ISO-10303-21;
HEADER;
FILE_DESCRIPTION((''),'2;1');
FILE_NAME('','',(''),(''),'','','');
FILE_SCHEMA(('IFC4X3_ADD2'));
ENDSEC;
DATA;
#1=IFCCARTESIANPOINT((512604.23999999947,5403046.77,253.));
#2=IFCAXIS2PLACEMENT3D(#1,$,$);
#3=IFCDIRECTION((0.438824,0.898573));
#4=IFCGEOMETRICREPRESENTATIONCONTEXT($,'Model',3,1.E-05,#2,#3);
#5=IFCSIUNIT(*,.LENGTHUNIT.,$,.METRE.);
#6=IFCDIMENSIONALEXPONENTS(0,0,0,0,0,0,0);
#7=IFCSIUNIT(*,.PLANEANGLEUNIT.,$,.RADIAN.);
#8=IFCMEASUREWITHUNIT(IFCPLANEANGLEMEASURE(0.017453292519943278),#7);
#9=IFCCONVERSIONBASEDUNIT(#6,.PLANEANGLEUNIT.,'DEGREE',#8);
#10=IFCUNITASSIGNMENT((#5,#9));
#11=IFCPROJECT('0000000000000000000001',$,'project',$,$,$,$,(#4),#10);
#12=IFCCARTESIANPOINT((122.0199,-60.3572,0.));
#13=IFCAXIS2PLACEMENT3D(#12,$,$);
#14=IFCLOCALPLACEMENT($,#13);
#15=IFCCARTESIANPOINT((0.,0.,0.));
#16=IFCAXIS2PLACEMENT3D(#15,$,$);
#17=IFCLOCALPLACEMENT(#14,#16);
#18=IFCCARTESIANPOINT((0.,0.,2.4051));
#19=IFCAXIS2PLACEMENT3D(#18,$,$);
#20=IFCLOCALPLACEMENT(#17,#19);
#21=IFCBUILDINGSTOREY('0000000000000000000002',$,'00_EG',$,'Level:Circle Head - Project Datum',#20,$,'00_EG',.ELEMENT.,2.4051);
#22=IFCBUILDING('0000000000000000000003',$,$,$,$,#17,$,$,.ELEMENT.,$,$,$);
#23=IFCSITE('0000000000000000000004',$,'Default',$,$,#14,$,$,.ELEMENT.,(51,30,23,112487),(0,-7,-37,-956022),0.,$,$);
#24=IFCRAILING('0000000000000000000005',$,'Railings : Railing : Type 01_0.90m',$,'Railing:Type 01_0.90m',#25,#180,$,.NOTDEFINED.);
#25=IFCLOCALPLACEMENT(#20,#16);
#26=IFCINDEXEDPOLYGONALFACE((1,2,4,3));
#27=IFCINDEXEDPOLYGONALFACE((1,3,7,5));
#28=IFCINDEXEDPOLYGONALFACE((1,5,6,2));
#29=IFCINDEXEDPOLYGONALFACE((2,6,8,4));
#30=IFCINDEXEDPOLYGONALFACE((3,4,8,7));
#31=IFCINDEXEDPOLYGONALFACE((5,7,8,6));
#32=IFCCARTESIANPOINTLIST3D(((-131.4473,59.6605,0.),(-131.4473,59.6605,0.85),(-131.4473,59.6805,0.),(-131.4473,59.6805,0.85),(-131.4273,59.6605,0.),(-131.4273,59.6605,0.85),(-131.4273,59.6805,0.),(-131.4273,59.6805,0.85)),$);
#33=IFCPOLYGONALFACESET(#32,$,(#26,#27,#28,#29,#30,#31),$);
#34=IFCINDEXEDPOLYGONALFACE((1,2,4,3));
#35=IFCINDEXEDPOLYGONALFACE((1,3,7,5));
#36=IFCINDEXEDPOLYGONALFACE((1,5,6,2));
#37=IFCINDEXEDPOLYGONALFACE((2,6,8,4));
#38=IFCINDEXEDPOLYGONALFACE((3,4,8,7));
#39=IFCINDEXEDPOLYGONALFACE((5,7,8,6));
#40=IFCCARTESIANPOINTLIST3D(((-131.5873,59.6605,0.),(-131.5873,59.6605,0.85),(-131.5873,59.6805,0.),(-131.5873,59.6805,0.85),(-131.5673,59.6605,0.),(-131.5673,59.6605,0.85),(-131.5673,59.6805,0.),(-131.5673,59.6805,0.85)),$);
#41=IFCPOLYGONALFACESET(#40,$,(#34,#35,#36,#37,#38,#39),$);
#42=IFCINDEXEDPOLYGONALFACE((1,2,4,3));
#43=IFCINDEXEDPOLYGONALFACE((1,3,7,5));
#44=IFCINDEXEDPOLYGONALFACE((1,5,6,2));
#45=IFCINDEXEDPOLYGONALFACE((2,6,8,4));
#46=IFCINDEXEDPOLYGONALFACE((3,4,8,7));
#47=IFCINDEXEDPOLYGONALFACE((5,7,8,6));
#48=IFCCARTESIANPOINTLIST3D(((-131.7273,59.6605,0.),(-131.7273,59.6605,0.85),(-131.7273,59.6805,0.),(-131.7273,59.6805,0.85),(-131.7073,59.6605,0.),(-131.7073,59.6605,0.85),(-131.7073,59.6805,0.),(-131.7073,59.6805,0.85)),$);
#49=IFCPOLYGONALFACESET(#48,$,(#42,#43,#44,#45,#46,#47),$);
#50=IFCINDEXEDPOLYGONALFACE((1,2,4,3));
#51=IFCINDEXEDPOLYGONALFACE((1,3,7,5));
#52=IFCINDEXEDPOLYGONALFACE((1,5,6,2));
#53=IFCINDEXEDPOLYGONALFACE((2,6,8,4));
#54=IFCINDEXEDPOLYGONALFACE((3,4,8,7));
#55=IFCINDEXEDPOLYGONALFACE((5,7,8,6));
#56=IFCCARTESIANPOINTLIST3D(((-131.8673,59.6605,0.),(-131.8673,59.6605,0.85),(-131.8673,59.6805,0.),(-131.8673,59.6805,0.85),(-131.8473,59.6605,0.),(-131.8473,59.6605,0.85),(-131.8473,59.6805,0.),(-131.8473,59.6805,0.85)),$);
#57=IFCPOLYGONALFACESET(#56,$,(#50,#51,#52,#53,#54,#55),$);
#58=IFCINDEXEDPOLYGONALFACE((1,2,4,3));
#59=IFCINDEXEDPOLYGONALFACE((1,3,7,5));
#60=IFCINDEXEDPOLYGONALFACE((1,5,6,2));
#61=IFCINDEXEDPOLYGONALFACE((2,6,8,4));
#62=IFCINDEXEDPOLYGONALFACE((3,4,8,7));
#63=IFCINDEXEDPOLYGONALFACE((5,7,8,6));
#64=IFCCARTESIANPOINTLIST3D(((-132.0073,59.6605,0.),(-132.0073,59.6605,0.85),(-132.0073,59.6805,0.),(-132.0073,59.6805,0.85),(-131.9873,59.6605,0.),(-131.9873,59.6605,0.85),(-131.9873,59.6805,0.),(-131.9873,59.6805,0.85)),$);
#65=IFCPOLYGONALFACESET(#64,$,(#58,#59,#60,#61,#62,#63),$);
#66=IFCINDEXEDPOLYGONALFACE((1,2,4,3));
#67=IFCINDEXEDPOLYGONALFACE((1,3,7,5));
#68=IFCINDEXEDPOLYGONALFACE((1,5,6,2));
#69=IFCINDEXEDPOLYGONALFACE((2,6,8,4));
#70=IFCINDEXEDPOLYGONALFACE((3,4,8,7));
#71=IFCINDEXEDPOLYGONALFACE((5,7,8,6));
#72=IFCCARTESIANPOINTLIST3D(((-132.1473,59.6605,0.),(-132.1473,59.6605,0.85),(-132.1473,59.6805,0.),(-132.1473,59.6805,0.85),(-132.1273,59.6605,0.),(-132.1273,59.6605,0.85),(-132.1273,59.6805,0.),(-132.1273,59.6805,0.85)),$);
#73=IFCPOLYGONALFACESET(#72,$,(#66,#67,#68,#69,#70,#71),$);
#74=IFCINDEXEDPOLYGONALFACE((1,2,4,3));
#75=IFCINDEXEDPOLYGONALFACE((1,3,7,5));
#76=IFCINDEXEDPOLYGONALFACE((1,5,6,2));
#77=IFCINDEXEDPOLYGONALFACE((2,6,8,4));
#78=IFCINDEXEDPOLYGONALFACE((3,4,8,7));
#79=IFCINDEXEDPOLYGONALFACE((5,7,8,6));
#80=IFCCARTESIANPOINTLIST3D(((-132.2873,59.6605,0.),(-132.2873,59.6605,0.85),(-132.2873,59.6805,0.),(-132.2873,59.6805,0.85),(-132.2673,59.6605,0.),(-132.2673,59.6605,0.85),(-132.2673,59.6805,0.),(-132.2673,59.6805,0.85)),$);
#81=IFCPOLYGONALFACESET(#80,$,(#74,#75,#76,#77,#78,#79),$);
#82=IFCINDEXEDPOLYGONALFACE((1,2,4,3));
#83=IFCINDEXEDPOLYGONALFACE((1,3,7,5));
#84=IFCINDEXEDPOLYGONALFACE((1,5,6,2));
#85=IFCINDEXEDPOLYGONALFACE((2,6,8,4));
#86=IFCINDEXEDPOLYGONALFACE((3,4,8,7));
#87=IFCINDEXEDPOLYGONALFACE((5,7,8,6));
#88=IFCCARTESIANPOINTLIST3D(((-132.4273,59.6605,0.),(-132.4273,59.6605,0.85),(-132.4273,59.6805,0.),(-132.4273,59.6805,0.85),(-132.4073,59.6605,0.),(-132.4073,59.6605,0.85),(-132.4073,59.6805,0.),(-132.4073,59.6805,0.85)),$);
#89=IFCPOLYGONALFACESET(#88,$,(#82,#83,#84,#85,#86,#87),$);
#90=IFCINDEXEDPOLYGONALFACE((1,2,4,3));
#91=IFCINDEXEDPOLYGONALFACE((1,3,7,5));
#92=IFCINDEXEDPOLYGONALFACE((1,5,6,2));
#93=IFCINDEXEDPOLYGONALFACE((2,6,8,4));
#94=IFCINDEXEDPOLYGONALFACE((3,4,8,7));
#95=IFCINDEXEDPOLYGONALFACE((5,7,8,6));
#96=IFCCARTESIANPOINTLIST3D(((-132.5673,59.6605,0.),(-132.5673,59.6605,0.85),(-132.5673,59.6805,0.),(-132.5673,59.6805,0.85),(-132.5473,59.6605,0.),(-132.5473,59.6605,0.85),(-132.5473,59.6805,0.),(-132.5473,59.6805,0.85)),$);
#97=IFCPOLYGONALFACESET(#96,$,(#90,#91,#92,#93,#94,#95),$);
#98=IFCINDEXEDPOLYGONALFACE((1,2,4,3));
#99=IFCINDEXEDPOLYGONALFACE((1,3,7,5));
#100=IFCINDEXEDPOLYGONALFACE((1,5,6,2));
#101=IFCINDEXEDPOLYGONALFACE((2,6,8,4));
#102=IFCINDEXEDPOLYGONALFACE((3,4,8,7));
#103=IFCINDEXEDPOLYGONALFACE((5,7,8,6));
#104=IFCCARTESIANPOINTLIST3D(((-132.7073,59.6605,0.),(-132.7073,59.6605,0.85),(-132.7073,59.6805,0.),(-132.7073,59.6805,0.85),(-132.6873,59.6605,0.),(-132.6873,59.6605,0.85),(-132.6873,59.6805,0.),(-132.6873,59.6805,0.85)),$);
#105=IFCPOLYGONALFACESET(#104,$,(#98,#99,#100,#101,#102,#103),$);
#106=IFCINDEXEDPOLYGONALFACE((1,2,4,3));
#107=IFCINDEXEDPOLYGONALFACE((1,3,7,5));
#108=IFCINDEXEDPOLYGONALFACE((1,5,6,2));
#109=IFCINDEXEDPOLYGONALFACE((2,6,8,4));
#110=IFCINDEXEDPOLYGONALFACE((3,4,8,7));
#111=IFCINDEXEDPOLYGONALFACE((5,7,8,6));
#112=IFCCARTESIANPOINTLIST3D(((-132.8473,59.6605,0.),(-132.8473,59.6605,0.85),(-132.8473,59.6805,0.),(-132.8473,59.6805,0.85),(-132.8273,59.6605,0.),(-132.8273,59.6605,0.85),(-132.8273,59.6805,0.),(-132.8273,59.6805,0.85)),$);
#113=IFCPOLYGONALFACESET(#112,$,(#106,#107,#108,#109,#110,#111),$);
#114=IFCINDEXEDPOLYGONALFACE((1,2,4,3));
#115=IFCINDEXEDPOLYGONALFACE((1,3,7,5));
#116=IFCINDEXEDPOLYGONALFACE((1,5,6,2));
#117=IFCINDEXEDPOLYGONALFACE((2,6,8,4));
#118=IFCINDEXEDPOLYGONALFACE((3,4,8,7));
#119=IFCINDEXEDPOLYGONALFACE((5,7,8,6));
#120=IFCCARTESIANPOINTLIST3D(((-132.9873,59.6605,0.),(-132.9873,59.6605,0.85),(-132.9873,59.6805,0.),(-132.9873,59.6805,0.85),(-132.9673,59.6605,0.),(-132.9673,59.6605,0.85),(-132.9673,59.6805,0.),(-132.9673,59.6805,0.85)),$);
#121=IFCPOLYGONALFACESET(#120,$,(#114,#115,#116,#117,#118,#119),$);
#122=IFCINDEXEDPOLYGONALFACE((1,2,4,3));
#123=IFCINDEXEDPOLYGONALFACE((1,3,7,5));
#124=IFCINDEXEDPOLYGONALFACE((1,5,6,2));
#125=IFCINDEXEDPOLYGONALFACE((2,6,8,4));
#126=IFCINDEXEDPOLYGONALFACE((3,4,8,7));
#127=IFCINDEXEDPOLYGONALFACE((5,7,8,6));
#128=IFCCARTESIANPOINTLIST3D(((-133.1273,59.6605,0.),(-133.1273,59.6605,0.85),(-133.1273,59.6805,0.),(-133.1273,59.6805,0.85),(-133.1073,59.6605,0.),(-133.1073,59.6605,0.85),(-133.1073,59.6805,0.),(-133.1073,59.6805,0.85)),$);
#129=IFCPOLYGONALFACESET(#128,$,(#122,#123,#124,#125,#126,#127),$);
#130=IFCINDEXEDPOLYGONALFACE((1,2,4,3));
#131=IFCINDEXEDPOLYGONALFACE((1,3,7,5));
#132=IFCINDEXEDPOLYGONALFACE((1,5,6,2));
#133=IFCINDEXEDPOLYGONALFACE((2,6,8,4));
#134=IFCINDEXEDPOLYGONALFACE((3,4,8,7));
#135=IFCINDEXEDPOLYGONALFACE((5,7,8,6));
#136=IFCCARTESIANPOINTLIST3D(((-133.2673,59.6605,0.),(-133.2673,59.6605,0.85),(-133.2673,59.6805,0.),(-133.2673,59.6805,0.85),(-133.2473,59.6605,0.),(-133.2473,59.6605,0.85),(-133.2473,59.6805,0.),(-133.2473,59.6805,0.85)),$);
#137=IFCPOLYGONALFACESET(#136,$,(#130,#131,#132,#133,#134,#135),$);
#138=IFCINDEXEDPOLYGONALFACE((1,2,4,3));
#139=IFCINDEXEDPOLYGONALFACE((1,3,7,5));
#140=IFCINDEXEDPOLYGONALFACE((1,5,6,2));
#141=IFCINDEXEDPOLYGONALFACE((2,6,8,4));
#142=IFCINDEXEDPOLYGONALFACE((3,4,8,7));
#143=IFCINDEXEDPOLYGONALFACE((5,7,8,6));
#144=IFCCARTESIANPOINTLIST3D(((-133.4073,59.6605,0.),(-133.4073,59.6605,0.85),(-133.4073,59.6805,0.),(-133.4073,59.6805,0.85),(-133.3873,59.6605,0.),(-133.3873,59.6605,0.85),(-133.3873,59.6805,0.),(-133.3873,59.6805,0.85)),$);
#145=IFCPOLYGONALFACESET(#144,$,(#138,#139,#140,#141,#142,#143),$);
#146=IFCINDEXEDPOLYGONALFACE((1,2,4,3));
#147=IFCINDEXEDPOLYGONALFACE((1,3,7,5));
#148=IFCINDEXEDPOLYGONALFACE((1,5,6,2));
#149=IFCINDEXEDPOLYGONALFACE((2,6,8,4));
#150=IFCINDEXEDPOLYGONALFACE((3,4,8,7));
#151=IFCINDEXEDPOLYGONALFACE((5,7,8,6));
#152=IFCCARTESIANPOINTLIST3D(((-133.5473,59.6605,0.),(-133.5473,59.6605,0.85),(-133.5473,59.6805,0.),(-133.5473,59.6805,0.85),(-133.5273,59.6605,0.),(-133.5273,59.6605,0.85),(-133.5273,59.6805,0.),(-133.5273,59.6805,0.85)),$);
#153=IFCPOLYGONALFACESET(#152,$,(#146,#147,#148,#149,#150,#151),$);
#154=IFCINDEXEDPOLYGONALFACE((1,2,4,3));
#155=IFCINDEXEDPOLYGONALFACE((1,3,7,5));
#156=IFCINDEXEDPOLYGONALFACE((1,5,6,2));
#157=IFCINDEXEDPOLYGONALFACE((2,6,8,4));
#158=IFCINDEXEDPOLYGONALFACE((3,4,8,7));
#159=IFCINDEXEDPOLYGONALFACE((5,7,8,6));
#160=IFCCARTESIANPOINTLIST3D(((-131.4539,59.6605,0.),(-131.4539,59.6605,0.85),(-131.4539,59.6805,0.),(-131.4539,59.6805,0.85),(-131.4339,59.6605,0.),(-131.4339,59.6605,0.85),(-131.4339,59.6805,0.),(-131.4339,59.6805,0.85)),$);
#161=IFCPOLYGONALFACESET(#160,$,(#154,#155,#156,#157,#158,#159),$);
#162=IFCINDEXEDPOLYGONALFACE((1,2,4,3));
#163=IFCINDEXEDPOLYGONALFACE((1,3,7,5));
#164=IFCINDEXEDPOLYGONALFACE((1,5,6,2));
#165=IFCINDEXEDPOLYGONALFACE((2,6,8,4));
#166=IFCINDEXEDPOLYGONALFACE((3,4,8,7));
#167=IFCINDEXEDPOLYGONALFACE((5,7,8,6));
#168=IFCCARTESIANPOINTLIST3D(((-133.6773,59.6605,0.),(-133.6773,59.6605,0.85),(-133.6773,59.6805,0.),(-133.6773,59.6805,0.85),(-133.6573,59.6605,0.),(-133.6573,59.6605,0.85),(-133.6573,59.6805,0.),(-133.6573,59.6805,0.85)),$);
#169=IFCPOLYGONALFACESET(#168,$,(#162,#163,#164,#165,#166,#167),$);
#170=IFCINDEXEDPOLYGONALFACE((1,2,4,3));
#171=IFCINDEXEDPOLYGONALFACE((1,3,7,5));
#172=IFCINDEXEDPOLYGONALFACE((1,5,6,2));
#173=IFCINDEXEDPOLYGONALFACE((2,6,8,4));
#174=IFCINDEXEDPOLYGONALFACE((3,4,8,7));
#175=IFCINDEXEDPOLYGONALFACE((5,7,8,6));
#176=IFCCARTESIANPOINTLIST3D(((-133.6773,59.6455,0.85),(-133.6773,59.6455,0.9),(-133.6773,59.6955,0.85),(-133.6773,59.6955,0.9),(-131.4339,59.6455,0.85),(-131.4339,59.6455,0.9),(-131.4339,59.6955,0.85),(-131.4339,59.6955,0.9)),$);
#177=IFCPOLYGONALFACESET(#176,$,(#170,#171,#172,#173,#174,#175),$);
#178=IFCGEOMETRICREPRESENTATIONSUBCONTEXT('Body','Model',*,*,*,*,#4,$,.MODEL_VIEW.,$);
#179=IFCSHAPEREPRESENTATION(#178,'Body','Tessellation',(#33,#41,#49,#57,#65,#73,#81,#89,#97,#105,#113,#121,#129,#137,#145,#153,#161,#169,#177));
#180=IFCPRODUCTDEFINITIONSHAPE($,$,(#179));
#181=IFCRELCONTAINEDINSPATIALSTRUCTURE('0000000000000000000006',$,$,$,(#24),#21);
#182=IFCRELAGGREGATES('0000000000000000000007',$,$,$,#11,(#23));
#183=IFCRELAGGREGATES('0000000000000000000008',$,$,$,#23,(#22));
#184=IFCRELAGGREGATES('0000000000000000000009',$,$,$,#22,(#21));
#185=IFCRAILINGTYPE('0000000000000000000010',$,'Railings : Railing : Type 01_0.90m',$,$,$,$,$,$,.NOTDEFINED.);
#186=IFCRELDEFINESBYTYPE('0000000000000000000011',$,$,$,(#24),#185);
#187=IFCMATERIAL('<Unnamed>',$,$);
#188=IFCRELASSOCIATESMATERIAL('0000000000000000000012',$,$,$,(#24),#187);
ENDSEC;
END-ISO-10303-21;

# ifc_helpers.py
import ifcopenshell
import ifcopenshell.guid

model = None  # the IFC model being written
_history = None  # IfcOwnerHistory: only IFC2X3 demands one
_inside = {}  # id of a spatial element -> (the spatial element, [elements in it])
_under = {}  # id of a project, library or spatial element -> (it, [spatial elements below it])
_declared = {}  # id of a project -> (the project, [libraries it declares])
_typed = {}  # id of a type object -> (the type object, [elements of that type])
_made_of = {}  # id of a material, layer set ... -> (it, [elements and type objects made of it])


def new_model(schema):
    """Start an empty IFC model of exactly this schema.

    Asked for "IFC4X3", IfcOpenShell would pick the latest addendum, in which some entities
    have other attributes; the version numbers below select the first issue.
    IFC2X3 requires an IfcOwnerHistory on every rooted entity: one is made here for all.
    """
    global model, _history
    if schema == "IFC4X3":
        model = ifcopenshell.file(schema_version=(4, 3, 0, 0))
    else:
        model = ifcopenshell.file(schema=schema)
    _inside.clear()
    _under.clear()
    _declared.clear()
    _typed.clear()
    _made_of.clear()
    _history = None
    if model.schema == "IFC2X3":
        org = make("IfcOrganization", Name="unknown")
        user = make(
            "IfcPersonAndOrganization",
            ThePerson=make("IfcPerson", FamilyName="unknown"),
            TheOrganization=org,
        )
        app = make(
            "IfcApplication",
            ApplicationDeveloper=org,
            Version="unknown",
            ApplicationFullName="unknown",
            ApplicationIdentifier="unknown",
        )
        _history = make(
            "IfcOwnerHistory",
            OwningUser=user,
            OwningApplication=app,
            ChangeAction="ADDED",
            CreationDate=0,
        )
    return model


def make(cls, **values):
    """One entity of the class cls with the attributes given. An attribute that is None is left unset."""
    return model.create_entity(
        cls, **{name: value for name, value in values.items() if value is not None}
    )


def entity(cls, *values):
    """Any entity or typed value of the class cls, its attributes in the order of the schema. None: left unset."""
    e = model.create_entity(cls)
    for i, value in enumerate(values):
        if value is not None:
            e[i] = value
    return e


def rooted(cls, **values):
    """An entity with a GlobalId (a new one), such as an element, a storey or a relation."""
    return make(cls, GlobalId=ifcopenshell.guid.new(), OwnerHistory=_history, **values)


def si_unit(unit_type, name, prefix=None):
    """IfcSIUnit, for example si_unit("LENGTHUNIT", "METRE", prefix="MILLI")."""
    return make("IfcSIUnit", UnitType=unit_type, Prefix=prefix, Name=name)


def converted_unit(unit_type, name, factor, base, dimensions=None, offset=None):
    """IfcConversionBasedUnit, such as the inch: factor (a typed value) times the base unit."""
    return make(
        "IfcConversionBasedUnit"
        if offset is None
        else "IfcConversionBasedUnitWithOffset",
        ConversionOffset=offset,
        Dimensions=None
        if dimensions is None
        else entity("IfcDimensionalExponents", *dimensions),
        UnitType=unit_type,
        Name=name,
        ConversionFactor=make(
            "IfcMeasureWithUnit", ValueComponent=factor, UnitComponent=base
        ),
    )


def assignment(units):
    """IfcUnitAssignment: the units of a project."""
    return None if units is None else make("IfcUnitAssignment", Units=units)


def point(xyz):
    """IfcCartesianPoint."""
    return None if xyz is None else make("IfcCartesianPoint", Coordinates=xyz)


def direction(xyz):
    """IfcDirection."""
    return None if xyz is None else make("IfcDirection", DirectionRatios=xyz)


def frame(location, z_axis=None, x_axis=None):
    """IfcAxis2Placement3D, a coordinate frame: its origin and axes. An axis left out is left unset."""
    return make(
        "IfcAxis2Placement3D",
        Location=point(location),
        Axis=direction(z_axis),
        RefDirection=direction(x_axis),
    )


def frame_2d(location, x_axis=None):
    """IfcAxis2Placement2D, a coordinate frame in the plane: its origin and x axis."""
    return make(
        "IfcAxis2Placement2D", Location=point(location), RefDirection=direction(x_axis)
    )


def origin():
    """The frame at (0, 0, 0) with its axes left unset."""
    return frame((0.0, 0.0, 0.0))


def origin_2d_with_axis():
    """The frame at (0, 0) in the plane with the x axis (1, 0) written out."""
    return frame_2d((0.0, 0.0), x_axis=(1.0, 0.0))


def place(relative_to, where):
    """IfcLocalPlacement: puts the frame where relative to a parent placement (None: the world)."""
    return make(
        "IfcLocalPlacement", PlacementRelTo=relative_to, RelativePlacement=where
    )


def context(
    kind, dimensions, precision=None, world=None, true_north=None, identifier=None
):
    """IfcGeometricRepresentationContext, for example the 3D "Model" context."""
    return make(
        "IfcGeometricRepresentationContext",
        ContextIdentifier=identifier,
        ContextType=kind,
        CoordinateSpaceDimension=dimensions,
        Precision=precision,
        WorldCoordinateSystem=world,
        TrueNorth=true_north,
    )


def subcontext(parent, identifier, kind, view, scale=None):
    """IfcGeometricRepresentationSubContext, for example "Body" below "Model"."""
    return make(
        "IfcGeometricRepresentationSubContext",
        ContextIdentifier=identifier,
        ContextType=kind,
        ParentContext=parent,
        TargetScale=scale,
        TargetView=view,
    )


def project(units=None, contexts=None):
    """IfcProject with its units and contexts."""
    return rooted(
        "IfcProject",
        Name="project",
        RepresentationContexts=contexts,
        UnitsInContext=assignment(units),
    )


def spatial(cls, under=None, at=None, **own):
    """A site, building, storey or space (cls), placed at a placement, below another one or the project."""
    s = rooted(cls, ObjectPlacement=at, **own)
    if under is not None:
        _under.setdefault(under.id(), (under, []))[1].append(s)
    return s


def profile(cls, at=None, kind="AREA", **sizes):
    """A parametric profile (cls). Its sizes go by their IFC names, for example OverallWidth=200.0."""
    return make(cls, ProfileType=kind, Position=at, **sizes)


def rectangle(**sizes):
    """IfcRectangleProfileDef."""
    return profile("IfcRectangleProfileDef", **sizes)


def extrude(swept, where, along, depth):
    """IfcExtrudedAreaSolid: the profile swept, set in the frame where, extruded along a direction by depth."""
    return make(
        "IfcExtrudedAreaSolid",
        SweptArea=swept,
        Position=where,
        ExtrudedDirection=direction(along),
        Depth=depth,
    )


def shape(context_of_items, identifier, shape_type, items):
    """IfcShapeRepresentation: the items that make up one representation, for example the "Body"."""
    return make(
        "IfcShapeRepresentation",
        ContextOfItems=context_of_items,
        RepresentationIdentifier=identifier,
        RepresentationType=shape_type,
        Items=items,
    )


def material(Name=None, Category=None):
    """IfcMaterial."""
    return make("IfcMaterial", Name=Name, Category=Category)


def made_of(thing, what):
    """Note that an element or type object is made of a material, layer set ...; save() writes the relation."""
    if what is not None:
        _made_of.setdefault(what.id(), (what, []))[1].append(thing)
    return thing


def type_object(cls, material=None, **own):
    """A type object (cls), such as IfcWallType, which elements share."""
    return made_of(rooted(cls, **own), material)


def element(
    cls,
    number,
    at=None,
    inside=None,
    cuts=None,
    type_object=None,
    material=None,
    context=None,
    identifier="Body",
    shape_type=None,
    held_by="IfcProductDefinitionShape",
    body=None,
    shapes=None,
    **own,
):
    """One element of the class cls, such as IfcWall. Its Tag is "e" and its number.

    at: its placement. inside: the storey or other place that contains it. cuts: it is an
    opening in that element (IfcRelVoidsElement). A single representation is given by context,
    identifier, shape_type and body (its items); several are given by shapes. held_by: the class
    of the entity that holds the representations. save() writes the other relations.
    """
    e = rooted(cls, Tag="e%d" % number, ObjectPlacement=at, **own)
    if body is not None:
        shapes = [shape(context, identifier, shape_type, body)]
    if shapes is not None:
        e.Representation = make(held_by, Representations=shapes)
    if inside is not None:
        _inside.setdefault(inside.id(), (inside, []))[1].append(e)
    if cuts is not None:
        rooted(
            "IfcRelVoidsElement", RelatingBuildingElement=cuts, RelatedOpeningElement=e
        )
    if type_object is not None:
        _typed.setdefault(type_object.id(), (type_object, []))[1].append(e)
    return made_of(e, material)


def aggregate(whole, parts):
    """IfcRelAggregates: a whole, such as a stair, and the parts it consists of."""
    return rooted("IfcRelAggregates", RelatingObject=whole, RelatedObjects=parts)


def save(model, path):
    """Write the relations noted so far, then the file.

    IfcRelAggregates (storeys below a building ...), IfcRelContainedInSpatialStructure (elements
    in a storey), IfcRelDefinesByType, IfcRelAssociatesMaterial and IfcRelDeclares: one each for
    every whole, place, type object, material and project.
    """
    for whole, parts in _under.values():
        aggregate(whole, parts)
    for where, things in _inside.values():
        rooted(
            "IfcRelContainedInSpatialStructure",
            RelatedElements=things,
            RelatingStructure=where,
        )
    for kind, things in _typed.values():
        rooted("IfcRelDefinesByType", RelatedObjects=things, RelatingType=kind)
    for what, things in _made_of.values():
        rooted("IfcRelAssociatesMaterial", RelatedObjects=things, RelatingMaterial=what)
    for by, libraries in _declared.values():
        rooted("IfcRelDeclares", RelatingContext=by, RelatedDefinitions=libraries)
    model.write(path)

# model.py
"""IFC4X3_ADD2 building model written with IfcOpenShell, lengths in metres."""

from ifc_helpers import new_model, entity, si_unit, converted_unit, direction, frame, frame_2d, origin, origin_2d_with_axis, place, context, subcontext, project, spatial, rectangle, extrude, material, type_object, element, save


model = new_model("IFC4X3_ADD2")

# Units and contexts
model_context = context("Model", 3, precision=1e-05, world=frame((512604.23999999947, 5403046.77, 253.0)), true_north=direction((0.438824, 0.898573)))
body_context = subcontext(model_context, "Body", "Model", "MODEL_VIEW")
ifc_project = project(units=[si_unit("LENGTHUNIT", "METRE"), converted_unit("PLANEANGLEUNIT", "DEGREE", entity("IfcPlaneAngleMeasure", 0.017453292519943278), si_unit("PLANEANGLEUNIT", "RADIAN"), dimensions=[0, 0, 0, 0, 0, 0, 0])], contexts=[model_context])

# Site, building, storey
site_placement = place(None, frame((122.0199, -60.3572, 0.0)))
site = spatial("IfcSite", under=ifc_project, at=site_placement, Name="Default", CompositionType="ELEMENT", RefLatitude=(51, 30, 23, 112487), RefLongitude=(0, -7, -37, -956022), RefElevation=0.0)
building_placement = place(site_placement, origin())
building = spatial("IfcBuilding", under=site, at=building_placement, CompositionType="ELEMENT")
storey_placement = place(building_placement, frame((0.0, 0.0, 2.4051)))
storey = spatial("IfcBuildingStorey", under=building, at=storey_placement, Name="00_EG", ObjectType="Level:Circle Head - Project Datum", LongName="00_EG", CompositionType="ELEMENT", Elevation=2.4051)

# Railing
ifc_material_1 = material(Name="<Unnamed>")
railing_type = type_object("IfcRailingType", Name="Railings : Railing : Type 01_0.90m", PredefinedType="NOTDEFINED")
railing_1_placement = place(storey_placement, frame((-133.6773, 59.6455, 0.0)))
element("IfcRailing", 1, at=railing_1_placement, inside=storey, type_object=railing_type, material=ifc_material_1, Name="Railings : Railing : Type 01_0.90m", ObjectType="Railing:Type 01_0.90m", PredefinedType="NOTDEFINED", context=body_context, shape_type="SweptSolid", body=[
    extrude(rectangle(XDim=0.02, YDim=0.02, at=origin_2d_with_axis()), frame((2.24, 0.025, 0.0)), (0.0, 0.0, 1.0), 0.85),
    extrude(rectangle(XDim=0.02, YDim=0.02, at=origin_2d_with_axis()), frame((2.1, 0.025, 0.0)), (0.0, 0.0, 1.0), 0.85),
    extrude(rectangle(XDim=0.02, YDim=0.02, at=origin_2d_with_axis()), frame((1.96, 0.025, 0.0)), (0.0, 0.0, 1.0), 0.85),
    extrude(rectangle(XDim=0.02, YDim=0.02, at=origin_2d_with_axis()), frame((1.82, 0.025, 0.0)), (0.0, 0.0, 1.0), 0.85),
    extrude(rectangle(XDim=0.02, YDim=0.02, at=origin_2d_with_axis()), frame((1.68, 0.025, 0.0)), (0.0, 0.0, 1.0), 0.85),
    extrude(rectangle(XDim=0.02, YDim=0.02, at=origin_2d_with_axis()), frame((1.54, 0.025, 0.0)), (0.0, 0.0, 1.0), 0.85),
    extrude(rectangle(XDim=0.02, YDim=0.02, at=origin_2d_with_axis()), frame((1.4, 0.025, 0.0)), (0.0, 0.0, 1.0), 0.85),
    extrude(rectangle(XDim=0.02, YDim=0.02, at=origin_2d_with_axis()), frame((1.26, 0.025, 0.0)), (0.0, 0.0, 1.0), 0.85),
    extrude(rectangle(XDim=0.02, YDim=0.02, at=origin_2d_with_axis()), frame((1.12, 0.025, 0.0)), (0.0, 0.0, 1.0), 0.85),
    extrude(rectangle(XDim=0.02, YDim=0.02, at=origin_2d_with_axis()), frame((0.98, 0.025, 0.0)), (0.0, 0.0, 1.0), 0.85),
    extrude(rectangle(XDim=0.02, YDim=0.02, at=origin_2d_with_axis()), frame((0.84, 0.025, 0.0)), (0.0, 0.0, 1.0), 0.85),
    extrude(rectangle(XDim=0.02, YDim=0.02, at=origin_2d_with_axis()), frame((0.7, 0.025, 0.0)), (0.0, 0.0, 1.0), 0.85),
    extrude(rectangle(XDim=0.02, YDim=0.02, at=origin_2d_with_axis()), frame((0.56, 0.025, 0.0)), (0.0, 0.0, 1.0), 0.85),
    extrude(rectangle(XDim=0.02, YDim=0.02, at=origin_2d_with_axis()), frame((0.42, 0.025, 0.0)), (0.0, 0.0, 1.0), 0.85),
    extrude(rectangle(XDim=0.02, YDim=0.02, at=origin_2d_with_axis()), frame((0.28, 0.025, 0.0)), (0.0, 0.0, 1.0), 0.85),
    extrude(rectangle(XDim=0.02, YDim=0.02, at=origin_2d_with_axis()), frame((0.14, 0.025, 0.0)), (0.0, 0.0, 1.0), 0.85),
    extrude(rectangle(XDim=0.02, YDim=0.02, at=origin_2d_with_axis()), frame((2.2334, 0.025, 0.0)), (0.0, 0.0, 1.0), 0.85),
    extrude(rectangle(XDim=0.02, YDim=0.02, at=origin_2d_with_axis()), frame((0.01, 0.025, 0.0)), (0.0, 0.0, 1.0), 0.85),
    extrude(rectangle(XDim=2.2434, YDim=0.05, at=frame_2d((0.0, 0.0), x_axis=(1.0, 0.0))), frame((1.1217, 0.025, 0.85)), (0.0, 0.0, 1.0), 0.05),
])

save(model, "model.ifc")
